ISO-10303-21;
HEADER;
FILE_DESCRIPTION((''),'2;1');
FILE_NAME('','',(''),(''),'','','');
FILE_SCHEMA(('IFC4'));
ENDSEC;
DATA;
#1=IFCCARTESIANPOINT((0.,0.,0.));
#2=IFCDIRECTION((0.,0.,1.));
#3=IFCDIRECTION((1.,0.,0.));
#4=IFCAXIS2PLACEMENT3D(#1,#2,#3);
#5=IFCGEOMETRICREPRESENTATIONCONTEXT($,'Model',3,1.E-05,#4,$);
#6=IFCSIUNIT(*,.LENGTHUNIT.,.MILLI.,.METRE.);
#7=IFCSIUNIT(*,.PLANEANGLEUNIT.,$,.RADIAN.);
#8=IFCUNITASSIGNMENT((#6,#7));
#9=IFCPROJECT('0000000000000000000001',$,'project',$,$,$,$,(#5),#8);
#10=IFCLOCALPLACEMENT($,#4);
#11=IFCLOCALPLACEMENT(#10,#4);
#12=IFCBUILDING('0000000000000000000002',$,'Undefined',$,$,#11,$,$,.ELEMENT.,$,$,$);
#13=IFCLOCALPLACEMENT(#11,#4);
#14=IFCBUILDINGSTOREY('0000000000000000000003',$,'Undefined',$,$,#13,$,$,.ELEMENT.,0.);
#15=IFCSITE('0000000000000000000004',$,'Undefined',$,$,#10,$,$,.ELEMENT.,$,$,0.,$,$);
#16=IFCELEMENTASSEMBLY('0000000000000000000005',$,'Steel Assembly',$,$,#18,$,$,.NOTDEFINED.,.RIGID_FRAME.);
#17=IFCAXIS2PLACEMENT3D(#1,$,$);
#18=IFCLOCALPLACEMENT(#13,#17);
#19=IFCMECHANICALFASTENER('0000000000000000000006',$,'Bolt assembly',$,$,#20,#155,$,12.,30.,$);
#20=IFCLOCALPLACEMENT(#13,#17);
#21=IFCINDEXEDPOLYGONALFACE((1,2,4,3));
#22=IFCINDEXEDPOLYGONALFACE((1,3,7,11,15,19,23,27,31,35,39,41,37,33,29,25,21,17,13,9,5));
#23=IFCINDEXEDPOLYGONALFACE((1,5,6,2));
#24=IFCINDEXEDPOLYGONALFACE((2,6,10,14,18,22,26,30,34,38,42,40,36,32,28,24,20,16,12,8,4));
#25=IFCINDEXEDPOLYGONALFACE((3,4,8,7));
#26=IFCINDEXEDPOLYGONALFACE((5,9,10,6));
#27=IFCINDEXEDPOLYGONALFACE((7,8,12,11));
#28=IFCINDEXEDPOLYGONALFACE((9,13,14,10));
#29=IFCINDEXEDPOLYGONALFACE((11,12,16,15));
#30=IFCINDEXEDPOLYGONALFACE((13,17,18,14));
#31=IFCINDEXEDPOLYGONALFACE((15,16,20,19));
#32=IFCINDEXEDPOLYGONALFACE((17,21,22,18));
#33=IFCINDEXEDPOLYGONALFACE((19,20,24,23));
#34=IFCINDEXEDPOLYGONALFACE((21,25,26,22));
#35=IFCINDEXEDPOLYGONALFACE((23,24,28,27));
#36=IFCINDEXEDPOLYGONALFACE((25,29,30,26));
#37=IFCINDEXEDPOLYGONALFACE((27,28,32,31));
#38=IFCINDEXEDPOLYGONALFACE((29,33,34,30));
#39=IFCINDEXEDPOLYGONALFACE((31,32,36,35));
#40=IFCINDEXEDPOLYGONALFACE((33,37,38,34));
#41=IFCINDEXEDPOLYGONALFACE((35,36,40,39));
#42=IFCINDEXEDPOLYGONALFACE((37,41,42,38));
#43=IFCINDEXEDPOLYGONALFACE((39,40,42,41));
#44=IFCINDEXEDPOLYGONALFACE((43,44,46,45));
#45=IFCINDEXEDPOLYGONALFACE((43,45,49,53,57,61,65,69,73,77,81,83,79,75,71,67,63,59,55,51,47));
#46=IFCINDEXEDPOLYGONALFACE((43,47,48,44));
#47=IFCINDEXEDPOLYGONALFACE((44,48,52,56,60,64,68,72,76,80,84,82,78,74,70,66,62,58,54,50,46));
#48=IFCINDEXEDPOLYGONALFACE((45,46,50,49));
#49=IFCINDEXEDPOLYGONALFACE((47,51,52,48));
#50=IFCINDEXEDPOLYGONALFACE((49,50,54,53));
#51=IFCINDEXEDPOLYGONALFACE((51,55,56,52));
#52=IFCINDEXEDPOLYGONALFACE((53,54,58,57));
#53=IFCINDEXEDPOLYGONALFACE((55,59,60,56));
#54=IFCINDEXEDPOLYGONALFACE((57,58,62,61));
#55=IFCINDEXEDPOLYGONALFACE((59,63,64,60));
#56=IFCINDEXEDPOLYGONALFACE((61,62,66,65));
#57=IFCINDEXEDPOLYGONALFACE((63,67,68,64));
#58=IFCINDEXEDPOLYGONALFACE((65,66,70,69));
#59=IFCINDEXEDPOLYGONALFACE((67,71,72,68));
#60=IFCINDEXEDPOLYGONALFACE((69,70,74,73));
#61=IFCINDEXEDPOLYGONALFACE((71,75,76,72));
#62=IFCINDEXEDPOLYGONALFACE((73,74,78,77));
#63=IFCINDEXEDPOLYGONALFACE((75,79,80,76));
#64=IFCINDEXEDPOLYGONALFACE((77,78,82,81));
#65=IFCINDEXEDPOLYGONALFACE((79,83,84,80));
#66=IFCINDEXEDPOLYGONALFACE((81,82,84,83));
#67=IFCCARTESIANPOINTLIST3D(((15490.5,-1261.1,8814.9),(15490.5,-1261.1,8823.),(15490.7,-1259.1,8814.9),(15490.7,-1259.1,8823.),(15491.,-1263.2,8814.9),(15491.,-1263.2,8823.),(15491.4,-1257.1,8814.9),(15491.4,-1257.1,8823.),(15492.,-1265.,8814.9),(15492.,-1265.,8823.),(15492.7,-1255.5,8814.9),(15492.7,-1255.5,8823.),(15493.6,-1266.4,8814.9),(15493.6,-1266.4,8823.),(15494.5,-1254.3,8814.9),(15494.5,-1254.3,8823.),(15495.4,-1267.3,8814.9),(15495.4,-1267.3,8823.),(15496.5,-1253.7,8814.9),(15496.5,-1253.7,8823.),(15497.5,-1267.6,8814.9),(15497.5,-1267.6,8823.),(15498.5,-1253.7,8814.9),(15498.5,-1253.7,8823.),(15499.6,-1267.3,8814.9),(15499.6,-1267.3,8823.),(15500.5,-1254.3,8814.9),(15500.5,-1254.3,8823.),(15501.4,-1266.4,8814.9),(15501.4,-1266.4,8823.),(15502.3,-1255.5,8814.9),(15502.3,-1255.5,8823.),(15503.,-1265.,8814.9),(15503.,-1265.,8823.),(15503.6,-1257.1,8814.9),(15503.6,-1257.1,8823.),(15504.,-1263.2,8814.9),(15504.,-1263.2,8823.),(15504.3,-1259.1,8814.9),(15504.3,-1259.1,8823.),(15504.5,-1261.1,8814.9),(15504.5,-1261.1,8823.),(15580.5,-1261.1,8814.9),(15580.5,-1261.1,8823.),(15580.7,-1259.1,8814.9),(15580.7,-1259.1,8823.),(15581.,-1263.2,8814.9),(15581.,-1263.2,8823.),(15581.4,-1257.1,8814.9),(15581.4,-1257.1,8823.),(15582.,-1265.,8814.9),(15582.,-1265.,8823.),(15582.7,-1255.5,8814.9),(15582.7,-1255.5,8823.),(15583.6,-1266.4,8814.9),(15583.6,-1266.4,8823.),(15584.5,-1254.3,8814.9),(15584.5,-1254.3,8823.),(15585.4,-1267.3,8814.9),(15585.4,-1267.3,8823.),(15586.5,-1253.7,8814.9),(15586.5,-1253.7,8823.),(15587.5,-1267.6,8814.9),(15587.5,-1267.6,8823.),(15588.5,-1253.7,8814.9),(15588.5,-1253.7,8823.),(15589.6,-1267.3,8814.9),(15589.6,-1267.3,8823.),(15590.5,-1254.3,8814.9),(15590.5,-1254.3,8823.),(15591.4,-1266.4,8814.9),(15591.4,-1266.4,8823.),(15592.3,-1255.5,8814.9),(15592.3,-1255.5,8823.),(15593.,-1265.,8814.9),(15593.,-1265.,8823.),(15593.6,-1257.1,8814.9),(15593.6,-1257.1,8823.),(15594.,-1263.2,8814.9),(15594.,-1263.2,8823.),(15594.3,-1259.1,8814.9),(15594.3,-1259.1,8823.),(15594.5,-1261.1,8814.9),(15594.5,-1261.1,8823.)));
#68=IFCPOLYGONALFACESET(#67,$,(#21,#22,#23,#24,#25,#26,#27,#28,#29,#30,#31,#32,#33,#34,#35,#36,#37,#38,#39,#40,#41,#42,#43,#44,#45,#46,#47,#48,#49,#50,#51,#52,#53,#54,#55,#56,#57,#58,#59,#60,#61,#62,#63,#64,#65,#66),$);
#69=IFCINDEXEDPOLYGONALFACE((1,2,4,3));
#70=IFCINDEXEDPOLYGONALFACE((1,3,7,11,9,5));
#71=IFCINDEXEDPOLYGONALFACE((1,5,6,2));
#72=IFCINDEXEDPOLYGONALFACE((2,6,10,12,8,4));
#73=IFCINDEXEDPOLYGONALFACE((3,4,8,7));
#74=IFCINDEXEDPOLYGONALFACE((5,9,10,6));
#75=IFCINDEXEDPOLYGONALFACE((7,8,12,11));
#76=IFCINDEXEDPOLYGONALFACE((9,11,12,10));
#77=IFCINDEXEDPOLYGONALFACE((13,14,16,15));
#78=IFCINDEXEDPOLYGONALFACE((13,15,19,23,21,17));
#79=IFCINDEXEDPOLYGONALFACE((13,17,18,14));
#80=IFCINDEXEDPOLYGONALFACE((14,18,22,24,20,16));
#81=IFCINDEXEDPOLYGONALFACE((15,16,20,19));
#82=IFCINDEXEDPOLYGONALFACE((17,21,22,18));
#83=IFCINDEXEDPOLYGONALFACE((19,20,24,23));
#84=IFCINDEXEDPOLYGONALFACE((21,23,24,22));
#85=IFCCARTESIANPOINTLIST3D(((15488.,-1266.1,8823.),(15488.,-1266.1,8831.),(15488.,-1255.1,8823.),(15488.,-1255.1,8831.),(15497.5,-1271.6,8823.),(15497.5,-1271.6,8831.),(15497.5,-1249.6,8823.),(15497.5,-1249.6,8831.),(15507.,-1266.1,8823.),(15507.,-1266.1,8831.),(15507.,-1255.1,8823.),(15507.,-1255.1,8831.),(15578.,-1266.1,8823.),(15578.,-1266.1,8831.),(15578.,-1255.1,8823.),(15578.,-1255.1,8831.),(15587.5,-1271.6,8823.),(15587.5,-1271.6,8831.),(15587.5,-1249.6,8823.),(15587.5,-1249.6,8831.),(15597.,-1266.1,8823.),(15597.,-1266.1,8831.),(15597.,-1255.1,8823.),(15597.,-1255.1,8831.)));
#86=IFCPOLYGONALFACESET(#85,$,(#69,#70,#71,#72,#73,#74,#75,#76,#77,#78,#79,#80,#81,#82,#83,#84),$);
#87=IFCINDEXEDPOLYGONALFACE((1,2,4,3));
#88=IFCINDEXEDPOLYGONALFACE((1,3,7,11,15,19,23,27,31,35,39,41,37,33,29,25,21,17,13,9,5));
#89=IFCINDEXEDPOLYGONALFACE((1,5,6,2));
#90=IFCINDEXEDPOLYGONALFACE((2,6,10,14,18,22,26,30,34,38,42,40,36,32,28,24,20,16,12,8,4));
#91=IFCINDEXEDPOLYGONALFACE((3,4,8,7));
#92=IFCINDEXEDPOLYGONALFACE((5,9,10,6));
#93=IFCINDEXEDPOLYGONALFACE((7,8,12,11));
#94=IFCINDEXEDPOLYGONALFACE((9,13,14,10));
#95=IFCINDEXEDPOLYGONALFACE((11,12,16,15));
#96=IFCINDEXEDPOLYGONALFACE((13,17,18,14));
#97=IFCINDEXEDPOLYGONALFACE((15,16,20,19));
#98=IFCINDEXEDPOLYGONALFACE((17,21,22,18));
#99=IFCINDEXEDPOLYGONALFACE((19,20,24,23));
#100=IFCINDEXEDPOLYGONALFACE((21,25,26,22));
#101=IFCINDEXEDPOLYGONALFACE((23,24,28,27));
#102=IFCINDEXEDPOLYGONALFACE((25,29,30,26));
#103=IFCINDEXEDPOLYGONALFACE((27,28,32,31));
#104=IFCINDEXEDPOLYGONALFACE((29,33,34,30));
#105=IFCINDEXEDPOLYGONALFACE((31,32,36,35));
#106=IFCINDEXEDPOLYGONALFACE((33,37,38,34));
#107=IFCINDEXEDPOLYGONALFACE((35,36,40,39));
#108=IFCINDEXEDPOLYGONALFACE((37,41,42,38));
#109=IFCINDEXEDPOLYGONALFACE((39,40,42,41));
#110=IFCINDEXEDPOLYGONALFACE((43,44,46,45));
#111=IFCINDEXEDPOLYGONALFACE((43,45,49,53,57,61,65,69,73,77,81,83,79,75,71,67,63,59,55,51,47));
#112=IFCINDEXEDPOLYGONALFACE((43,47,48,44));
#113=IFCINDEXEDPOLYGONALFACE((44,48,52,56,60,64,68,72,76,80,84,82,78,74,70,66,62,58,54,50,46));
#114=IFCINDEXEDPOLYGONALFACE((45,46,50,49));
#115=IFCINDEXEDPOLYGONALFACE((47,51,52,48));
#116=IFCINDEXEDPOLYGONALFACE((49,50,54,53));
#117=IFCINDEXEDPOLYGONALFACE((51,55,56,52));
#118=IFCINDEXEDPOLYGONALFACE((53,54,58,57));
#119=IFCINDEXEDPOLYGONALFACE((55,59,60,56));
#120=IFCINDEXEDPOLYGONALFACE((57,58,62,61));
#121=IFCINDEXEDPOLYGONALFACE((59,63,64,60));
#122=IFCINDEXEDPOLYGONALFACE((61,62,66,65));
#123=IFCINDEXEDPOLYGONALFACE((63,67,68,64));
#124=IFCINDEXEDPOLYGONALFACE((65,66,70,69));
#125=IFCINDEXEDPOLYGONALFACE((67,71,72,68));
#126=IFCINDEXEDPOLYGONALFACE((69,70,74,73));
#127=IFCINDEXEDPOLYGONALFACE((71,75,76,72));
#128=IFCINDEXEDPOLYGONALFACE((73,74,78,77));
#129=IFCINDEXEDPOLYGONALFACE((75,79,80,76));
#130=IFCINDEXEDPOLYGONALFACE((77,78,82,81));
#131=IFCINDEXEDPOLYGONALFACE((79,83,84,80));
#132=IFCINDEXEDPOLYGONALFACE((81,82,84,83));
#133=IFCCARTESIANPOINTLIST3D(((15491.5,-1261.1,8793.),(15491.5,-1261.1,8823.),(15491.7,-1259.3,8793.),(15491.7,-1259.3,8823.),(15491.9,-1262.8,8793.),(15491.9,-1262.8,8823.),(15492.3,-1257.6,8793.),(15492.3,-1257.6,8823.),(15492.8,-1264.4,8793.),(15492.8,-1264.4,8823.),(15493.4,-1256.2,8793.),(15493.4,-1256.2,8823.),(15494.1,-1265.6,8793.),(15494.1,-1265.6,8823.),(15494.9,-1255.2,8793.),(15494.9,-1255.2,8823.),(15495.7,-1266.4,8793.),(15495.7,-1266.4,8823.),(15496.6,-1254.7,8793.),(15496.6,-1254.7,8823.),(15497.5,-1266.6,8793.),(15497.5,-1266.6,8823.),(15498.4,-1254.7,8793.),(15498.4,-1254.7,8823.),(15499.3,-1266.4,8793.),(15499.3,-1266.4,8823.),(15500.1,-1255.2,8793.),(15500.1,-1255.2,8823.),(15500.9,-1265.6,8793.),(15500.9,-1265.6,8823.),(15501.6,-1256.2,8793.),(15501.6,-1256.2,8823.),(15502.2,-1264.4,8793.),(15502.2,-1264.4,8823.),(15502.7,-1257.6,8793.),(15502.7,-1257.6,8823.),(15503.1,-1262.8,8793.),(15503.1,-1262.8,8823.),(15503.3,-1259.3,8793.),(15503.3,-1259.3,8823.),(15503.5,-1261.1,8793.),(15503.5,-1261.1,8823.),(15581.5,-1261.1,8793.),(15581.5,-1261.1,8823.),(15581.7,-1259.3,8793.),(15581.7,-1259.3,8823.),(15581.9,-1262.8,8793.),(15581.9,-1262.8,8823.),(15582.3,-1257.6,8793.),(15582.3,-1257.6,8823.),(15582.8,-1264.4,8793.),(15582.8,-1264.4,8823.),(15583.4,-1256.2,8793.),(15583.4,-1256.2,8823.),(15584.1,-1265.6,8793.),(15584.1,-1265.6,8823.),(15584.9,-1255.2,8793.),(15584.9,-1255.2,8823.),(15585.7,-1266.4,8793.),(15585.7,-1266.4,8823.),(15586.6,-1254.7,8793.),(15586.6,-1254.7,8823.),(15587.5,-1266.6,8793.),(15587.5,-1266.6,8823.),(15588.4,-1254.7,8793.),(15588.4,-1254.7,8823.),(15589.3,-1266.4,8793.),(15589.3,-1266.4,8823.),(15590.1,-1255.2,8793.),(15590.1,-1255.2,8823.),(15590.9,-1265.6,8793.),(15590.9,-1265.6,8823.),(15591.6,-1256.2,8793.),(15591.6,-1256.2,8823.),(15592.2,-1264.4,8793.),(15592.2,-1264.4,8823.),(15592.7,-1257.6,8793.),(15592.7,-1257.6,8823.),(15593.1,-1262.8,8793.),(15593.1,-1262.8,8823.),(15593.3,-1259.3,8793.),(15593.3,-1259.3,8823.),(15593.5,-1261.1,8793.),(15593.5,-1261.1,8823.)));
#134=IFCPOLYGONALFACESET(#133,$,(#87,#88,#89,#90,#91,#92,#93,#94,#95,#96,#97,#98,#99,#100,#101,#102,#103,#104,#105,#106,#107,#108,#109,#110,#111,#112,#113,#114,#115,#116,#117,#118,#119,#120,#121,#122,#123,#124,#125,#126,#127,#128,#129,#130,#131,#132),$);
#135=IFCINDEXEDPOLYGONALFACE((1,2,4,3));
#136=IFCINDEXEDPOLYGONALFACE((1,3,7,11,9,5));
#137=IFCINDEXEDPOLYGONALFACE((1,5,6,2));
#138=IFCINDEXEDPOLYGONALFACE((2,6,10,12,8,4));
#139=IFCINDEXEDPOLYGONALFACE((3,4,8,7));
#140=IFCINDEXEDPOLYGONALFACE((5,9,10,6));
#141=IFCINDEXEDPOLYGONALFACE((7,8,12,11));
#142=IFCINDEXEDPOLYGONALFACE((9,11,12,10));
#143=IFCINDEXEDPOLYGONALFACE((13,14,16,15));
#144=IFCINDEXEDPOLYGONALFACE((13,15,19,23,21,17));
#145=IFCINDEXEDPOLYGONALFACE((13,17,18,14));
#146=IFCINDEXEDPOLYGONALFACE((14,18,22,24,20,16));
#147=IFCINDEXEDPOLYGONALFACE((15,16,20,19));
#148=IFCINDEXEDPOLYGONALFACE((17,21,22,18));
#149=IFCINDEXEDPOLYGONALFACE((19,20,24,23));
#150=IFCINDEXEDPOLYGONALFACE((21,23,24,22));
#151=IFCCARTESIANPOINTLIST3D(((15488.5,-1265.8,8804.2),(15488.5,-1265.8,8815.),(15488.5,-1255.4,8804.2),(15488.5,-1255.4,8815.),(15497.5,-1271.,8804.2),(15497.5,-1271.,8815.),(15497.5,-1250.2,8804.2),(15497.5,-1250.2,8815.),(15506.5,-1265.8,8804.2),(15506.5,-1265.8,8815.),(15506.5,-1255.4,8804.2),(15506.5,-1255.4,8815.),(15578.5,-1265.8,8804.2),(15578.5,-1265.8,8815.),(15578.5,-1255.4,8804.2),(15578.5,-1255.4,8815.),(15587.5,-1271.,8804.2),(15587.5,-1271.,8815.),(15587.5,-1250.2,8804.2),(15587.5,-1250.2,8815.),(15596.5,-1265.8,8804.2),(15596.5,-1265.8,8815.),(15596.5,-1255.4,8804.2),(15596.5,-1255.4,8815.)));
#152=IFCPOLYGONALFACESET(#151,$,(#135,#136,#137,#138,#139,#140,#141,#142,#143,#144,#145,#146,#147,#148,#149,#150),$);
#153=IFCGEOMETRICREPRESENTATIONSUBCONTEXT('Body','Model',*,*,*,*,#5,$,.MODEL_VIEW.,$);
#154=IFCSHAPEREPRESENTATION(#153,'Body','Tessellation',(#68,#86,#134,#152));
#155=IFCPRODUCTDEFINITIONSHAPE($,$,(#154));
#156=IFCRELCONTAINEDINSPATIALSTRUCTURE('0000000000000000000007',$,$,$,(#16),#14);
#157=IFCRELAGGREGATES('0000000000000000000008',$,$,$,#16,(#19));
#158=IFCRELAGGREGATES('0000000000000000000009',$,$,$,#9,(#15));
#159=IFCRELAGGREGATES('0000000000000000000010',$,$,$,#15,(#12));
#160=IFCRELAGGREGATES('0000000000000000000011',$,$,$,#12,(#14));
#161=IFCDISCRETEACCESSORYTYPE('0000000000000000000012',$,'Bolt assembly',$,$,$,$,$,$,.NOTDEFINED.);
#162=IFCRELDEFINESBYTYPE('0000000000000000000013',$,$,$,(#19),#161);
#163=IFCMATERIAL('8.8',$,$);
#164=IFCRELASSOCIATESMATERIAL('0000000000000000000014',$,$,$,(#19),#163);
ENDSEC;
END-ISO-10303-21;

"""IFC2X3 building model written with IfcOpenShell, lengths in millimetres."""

from ifc_helpers import new_model, si_unit, frame, origin_with_axes, origin_2d_with_axis, place, context, subcontext, project, spatial, polyline, circle, outline, extrude, source, transform, mapped, material, type_object, element, aggregate, save


model = new_model("IFC2X3")

# Units and contexts
model_context = context("Model", 3, precision=1e-05, world=origin_with_axes())
body_context = subcontext(model_context, "Body", "Model", "MODEL_VIEW")
ifc_project = project(units=[si_unit("LENGTHUNIT", "METRE", prefix="MILLI"), si_unit("PLANEANGLEUNIT", "RADIAN")], contexts=[model_context])

# Site, building, storey
site_placement = place(None, origin_with_axes())
site = spatial("IfcSite", under=ifc_project, at=site_placement, Name="Undefined", CompositionType="ELEMENT", RefElevation=0.0)
building_placement = place(site_placement, origin_with_axes())
building = spatial("IfcBuilding", under=site, at=building_placement, Name="Undefined", CompositionType="ELEMENT")
storey_placement = place(building_placement, origin_with_axes())
storey = spatial("IfcBuildingStorey", under=building, at=storey_placement, Name="Undefined", CompositionType="ELEMENT", Elevation=0.0)

# Element assembly, mechanical fastener
assembly_1_placement = place(storey_placement, origin_with_axes())
assembly_1 = element("IfcElementAssembly", 1, at=assembly_1_placement, inside=storey, Name="Steel Assembly", AssemblyPlace="NOTDEFINED", PredefinedType="RIGID_FRAME")
ifc_material_1 = material(Name="8.8")
discrete_accessory_type_1 = type_object("IfcDiscreteAccessoryType", Name="Bolt assembly")
shared_shape_1 = source(origin_with_axes(), body_context, "Body", "SweptSolid", [
    extrude(circle(Radius=7.0, at=origin_2d_with_axis()), frame((0.0, 0.0, 0.0), z_axis=(0.0, 1.0, 0.0), x_axis=(1.0, 0.0, 0.0)), (0.0, 0.0, 1.0), 8.1),
    extrude(outline(polyline([(11.0, 0.0), (5.5, 9.5), (-5.5, 9.5), (-11.0, 0.0), (-5.5, -9.5), (5.5, -9.5), (11.0, 0.0)])), frame((0.0, -8.0, 0.0), z_axis=(0.0, 1.0, 0.0), x_axis=(1.0, 0.0, 0.0)), (0.0, 0.0, 1.0), 8.0),
    extrude(circle(Radius=6.0, at=origin_2d_with_axis()), frame((0.0, 0.0, 0.0), z_axis=(0.0, 1.0, 0.0), x_axis=(1.0, 0.0, 0.0)), (0.0, 0.0, 1.0), 30.0),
    extrude(outline(polyline([(10.4, 0.0), (5.2, 9.0), (-5.2, 9.0), (-10.4, 0.0), (-5.2, -9.0), (5.2, -9.0), (10.4, 0.0)])), frame((0.0, 8.0, 0.0), z_axis=(0.0, 1.0, 0.0), x_axis=(1.0, 0.0, 0.0)), (0.0, 0.0, 1.0), 10.8),
])
mechanical_fastener_1_placement = place(assembly_1_placement, frame((15542.5, -1240.6, 8823.0), z_axis=(1.0, 0.0, 0.0), x_axis=(0.0, -1.0, 0.0)))
mechanical_fastener_1 = element("IfcMechanicalFastener", 2, at=mechanical_fastener_1_placement, type_object=discrete_accessory_type_1, material=ifc_material_1, Name="Bolt assembly", NominalDiameter=12.0, NominalLength=30.0, context=body_context, shape_type="MappedRepresentation", body=[
    mapped(shared_shape_1, transform((20.0, 0.0, -45.0))),
    mapped(shared_shape_1, transform((20.0, 0.0, 45.0))),
])

aggregate(assembly_1, [mechanical_fastener_1])

save(model, "model.ifc")
